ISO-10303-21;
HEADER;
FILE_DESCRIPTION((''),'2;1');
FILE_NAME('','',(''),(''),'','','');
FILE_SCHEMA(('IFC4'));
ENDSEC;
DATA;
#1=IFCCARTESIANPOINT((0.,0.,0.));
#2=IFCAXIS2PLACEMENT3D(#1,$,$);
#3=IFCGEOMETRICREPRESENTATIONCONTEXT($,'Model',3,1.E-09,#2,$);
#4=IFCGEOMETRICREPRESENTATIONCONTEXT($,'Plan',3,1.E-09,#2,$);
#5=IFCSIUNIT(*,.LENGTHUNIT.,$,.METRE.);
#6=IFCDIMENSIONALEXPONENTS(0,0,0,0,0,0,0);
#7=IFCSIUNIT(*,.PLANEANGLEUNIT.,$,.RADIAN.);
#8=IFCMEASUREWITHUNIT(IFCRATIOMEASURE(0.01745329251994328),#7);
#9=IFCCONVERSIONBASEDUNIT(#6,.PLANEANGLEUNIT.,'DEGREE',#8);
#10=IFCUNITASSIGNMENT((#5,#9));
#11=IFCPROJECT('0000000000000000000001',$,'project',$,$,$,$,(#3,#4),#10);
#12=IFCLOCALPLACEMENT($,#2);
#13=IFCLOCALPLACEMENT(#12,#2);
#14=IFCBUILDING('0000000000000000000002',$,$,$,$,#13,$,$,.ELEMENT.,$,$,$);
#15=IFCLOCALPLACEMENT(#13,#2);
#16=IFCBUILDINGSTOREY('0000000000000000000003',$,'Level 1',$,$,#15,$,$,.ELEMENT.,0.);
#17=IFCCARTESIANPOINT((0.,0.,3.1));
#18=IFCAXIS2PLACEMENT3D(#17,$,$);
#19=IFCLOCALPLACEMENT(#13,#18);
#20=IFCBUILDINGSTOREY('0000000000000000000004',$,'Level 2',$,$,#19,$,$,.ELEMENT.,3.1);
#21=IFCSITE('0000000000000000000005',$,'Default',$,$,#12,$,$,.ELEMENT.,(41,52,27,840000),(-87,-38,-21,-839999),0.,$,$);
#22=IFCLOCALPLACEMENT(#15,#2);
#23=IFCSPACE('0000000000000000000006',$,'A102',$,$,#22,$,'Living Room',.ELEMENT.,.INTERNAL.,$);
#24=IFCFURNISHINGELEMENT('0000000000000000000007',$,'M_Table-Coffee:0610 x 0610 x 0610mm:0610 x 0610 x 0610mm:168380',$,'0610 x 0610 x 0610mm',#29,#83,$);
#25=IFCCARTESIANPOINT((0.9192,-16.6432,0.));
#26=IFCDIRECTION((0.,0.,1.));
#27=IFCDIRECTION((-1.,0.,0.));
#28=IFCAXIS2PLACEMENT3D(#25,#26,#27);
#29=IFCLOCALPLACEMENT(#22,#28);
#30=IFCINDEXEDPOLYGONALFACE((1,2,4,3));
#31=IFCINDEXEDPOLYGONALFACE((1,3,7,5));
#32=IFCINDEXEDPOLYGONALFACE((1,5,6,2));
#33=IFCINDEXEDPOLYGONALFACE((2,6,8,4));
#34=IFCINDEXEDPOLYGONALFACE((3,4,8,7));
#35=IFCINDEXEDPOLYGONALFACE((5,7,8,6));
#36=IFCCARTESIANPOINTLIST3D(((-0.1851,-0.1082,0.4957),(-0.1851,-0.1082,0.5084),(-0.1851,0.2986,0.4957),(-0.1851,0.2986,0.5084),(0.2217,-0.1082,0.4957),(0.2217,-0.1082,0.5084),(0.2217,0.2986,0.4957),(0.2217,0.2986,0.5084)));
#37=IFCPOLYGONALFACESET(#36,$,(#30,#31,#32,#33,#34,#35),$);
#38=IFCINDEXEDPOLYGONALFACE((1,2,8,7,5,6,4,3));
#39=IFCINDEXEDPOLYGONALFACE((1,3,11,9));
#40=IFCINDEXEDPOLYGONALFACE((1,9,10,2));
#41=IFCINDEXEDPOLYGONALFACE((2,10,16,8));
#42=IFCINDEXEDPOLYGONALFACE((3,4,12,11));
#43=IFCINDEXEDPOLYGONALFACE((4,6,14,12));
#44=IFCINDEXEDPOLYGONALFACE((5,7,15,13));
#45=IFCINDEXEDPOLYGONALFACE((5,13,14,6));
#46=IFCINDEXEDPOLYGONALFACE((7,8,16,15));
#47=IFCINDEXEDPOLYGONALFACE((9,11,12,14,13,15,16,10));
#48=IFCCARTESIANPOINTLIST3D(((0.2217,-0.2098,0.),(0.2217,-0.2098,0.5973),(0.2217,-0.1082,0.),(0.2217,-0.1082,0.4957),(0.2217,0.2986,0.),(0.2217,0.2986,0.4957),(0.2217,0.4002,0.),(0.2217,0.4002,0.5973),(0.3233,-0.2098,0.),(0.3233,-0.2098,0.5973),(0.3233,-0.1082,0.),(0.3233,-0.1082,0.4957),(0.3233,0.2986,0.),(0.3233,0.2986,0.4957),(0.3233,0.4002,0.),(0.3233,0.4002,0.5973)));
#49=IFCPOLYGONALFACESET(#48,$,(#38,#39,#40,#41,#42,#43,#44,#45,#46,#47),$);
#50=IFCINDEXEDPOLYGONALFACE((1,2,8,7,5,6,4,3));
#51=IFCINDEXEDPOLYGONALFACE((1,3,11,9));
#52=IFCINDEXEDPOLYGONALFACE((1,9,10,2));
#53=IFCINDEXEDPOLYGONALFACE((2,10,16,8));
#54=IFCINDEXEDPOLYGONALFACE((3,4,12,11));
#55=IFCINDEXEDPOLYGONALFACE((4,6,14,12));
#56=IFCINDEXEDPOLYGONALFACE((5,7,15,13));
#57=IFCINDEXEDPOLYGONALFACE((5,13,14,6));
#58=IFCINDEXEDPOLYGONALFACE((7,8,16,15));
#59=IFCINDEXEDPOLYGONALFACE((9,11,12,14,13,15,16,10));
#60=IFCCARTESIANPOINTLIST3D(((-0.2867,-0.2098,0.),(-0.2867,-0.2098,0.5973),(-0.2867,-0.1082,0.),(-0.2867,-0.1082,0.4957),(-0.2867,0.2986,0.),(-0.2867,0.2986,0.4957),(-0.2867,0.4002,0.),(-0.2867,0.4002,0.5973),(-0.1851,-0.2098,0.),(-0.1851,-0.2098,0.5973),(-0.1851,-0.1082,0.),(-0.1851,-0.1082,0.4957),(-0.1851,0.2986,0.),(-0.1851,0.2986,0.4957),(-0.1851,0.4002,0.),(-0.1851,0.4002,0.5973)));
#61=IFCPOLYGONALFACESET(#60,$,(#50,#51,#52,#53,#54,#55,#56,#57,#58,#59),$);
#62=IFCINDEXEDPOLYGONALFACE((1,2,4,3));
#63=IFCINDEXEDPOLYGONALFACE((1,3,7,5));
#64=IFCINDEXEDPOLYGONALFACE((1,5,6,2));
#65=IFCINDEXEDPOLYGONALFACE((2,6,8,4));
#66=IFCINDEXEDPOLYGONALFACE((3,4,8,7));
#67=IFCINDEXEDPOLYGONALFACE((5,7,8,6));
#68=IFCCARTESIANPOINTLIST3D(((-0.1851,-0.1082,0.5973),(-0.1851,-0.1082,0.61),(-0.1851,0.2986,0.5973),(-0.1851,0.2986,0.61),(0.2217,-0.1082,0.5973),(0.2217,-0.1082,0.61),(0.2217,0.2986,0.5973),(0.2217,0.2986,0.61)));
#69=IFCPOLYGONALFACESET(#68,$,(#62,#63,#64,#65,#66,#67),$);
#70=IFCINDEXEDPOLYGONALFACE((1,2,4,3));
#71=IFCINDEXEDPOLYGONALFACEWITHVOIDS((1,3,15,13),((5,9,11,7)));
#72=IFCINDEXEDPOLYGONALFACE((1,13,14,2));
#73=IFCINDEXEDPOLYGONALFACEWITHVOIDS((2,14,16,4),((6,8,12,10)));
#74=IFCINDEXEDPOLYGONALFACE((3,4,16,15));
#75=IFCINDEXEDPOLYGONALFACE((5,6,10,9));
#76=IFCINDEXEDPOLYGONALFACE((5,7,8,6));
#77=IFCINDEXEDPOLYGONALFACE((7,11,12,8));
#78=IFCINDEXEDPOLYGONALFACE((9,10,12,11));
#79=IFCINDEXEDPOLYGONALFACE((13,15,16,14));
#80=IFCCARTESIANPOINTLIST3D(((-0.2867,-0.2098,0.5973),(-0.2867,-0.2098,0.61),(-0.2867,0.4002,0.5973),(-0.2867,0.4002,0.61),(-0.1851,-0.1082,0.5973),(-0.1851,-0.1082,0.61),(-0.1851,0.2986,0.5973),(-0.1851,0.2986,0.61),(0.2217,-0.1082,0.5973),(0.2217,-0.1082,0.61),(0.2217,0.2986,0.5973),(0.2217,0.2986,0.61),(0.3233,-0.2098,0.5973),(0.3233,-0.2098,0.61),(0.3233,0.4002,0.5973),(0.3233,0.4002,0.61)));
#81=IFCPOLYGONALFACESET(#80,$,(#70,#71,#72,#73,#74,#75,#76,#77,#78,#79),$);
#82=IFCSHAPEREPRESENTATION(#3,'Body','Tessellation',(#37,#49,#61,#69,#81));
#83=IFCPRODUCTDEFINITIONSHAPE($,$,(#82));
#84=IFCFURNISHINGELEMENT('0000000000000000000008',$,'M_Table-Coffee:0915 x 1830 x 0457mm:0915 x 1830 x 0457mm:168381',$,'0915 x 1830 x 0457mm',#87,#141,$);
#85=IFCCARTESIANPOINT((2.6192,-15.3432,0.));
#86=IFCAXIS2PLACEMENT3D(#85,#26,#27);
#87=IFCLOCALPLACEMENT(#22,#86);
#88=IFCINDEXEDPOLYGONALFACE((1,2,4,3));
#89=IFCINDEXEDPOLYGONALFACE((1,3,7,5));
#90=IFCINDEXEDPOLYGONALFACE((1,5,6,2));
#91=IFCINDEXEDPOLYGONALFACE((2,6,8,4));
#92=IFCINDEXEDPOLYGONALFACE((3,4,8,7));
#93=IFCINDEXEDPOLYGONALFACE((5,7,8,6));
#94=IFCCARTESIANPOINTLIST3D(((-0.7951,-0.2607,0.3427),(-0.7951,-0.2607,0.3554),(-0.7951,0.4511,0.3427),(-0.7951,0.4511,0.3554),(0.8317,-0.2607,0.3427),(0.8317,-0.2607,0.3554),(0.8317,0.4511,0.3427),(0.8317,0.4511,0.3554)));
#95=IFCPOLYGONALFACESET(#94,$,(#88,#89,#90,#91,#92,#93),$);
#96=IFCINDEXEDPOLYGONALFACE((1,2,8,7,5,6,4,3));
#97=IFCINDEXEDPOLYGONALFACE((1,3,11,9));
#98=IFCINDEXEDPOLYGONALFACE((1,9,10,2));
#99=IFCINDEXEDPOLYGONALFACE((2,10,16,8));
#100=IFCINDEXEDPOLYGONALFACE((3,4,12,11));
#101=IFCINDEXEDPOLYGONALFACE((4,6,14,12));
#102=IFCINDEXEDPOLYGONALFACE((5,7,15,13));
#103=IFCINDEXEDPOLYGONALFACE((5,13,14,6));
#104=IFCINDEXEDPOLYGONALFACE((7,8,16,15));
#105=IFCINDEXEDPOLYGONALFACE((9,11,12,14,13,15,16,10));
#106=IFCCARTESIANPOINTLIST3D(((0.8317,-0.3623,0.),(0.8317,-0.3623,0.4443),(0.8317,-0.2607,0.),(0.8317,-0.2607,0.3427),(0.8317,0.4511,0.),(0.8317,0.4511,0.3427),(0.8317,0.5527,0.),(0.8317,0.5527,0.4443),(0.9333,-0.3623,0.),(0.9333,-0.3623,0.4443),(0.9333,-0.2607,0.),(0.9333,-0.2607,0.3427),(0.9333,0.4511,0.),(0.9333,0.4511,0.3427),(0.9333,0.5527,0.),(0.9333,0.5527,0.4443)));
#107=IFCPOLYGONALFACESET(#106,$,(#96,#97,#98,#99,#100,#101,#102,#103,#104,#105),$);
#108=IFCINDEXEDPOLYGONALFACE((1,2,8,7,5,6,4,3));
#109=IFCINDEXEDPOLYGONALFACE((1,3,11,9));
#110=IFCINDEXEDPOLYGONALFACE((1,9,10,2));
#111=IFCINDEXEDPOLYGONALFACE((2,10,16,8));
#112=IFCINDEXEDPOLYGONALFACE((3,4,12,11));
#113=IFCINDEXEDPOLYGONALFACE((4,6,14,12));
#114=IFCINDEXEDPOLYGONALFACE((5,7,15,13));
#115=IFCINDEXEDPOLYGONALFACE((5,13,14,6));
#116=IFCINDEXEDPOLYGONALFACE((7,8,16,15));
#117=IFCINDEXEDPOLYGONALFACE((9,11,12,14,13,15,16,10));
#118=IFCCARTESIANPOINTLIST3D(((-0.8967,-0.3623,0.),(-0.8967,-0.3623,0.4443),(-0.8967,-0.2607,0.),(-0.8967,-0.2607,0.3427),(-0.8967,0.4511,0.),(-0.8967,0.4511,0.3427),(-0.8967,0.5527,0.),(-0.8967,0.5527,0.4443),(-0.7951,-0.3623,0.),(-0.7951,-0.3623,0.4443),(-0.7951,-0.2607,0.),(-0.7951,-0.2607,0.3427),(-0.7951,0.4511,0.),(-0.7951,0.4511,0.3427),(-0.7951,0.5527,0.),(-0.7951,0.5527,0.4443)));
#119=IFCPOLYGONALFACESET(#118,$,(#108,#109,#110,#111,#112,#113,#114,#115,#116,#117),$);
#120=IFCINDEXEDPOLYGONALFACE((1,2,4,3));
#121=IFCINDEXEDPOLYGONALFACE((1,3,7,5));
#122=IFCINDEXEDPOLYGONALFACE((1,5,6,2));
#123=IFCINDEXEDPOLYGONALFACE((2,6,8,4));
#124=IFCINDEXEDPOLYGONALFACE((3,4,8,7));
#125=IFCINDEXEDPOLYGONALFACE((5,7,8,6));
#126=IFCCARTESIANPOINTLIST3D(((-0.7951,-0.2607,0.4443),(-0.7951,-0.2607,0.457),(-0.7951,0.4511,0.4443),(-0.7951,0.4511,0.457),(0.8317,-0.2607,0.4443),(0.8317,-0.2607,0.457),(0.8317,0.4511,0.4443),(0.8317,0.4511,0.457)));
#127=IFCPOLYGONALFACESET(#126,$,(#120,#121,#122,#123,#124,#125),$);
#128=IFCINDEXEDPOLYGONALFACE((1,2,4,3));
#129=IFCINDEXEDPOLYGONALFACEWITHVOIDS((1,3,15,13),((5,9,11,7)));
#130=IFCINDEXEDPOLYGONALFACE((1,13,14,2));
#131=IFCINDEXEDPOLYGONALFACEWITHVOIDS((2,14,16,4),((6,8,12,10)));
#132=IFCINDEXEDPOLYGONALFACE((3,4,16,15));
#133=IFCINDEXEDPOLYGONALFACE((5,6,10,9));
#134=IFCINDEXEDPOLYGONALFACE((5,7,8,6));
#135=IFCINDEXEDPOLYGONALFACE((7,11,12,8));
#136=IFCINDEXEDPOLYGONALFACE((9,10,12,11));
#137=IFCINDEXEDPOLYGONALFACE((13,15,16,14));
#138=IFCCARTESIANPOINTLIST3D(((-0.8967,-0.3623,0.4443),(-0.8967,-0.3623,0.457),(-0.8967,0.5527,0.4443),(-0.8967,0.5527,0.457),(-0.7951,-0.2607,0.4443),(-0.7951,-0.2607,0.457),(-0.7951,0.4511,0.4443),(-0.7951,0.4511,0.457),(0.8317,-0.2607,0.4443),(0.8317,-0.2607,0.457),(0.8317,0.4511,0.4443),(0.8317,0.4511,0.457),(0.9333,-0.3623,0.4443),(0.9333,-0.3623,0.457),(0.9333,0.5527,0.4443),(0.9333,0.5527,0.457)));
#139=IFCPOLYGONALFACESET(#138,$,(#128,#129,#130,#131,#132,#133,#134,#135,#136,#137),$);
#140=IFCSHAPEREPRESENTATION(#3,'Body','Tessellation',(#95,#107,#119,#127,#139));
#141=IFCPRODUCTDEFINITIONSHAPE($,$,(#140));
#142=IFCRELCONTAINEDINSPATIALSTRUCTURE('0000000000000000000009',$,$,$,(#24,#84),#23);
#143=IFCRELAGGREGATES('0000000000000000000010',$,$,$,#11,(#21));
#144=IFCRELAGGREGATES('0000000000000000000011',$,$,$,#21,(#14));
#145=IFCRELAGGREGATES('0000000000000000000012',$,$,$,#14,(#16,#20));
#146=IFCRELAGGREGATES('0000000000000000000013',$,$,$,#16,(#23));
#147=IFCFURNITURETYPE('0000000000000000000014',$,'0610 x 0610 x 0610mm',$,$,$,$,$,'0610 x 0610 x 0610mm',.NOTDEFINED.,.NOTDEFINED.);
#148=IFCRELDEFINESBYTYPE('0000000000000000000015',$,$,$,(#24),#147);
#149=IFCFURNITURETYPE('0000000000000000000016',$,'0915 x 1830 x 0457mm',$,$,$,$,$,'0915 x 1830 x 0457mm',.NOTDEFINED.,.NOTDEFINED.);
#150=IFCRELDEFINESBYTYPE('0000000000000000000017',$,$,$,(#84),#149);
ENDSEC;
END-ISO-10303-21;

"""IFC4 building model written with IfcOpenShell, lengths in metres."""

from ifc_helpers import new_model, entity, si_unit, converted_unit, frame, origin, origin_2d_with_axis, place, context, project, spatial, polyline, rectangle, outline, extrude, source, transform, mapped, type_object, type_shapes, element, save


model = new_model("IFC4")

# Units and contexts
model_context = context("Model", 3, precision=1e-09, world=origin())
plan_context = context("Plan", 3, precision=1e-09, world=origin())
ifc_project = project(units=[si_unit("LENGTHUNIT", "METRE"), converted_unit("PLANEANGLEUNIT", "DEGREE", entity("IfcRatioMeasure", 0.01745329251994328), si_unit("PLANEANGLEUNIT", "RADIAN"), dimensions=[0, 0, 0, 0, 0, 0, 0])], contexts=[model_context, plan_context])

# Site, building, storey
site_placement = place(None, origin())
site = spatial("IfcSite", under=ifc_project, at=site_placement, Name="Default", CompositionType="ELEMENT", RefLatitude=(41, 52, 27, 840000), RefLongitude=(-87, -38, -21, -839999), RefElevation=0.0)
building_placement = place(site_placement, origin())
building = spatial("IfcBuilding", under=site, at=building_placement, CompositionType="ELEMENT")
storey_1_placement = place(building_placement, origin())
storey_1 = spatial("IfcBuildingStorey", under=building, at=storey_1_placement, Name="Level 1", CompositionType="ELEMENT", Elevation=0.0)

# Shared definitions
storey_2_placement = place(building_placement, frame((0.0, 0.0, 3.1)))
storey_2 = spatial("IfcBuildingStorey", under=building, at=storey_2_placement, Name="Level 2", CompositionType="ELEMENT", Elevation=3.1)

# Shared definitions
space_1_placement = place(storey_1_placement, origin())
space_1 = spatial("IfcSpace", under=storey_1, at=space_1_placement, Name="A102", LongName="Living Room", CompositionType="ELEMENT", PredefinedType="INTERNAL")

# Furnishing elements
furniture_type_1 = type_object("IfcFurnitureType", Name="0610 x 0610 x 0610mm", ElementType="0610 x 0610 x 0610mm", AssemblyPlace="NOTDEFINED")
shared_shape_1 = source(origin(), model_context, "Body", "SweptSolid", [
    extrude(rectangle(XDim=0.4068, YDim=0.4068, at=origin_2d_with_axis()), frame((0.0183, 0.0952, 0.4957), z_axis=(0.0, 0.0, 1.0), x_axis=(-1.0, 0.0, 0.0)), (0.0, 0.0, 1.0), 0.0127),
    extrude(outline(polyline([(-0.2732, -0.305), (0.324, -0.305), (0.324, 0.305), (-0.2732, 0.305), (-0.2732, 0.2034), (0.2225, 0.2034), (0.2225, -0.2034), (-0.2732, -0.2034), (-0.2732, -0.305)])), frame((0.2217, 0.0952, 0.2732), z_axis=(1.0, 0.0, 0.0), x_axis=(0.0, 0.0, 1.0)), (0.0, 0.0, 1.0), 0.1016),
    extrude(outline(polyline([(-0.305, -0.3241), (0.305, -0.3241), (0.305, 0.2733), (0.2034, 0.2733), (0.2034, -0.2224), (-0.2034, -0.2224), (-0.2034, 0.2733), (-0.305, 0.2733), (-0.305, -0.3241)])), frame((-0.2867, 0.0952, 0.2733), z_axis=(1.0, 0.0, 0.0), x_axis=(0.0, -1.0, 0.0)), (0.0, 0.0, 1.0), 0.1016),
    extrude(rectangle(XDim=0.4068, YDim=0.4068, at=origin_2d_with_axis()), frame((0.0183, 0.0952, 0.5973), z_axis=(0.0, 0.0, 1.0), x_axis=(-1.0, 0.0, 0.0)), (0.0, 0.0, 1.0), 0.0127),
    extrude(outline(polyline([(-0.305, -0.305), (0.305, -0.305), (0.305, 0.305), (-0.305, 0.305), (-0.305, -0.305)]), holes=[polyline([(-0.2034, -0.2034), (-0.2034, 0.2034), (0.2034, 0.2034), (0.2034, -0.2034), (-0.2034, -0.2034)])]), frame((0.0183, 0.0952, 0.5973), z_axis=(0.0, 0.0, 1.0), x_axis=(-1.0, 0.0, 0.0)), (0.0, 0.0, 1.0), 0.0127),
])
type_shapes(furniture_type_1, [shared_shape_1])
for number, where, z_axis, x_axis, name in (
    (1, (0.9192, -16.6432, 0.0), (0.0, 0.0, 1.0), (-1.0, 0.0, 0.0), "M_Table-Coffee:0610 x 0610 x 0610mm:0610 x 0610 x 0610mm:168380"),
):
    element("IfcFurnishingElement", number, at=place(space_1_placement, frame(where, z_axis=z_axis, x_axis=x_axis)), inside=space_1, type_object=furniture_type_1, Name=name, ObjectType="0610 x 0610 x 0610mm", context=model_context, shape_type="MappedRepresentation", body=[
        mapped(shared_shape_1, transform((0.0, 0.0, 0.0), scale=1.0)),
    ])
furniture_type_2 = type_object("IfcFurnitureType", Name="0915 x 1830 x 0457mm", ElementType="0915 x 1830 x 0457mm", AssemblyPlace="NOTDEFINED")
shared_shape_2 = source(origin(), model_context, "Body", "SweptSolid", [
    extrude(rectangle(XDim=1.6268, YDim=0.7118, at=origin_2d_with_axis()), frame((0.0183, 0.0952, 0.3427), z_axis=(0.0, 0.0, 1.0), x_axis=(-1.0, 0.0, 0.0)), (0.0, 0.0, 1.0), 0.0127),
    extrude(outline(polyline([(-0.1967, -0.4575), (0.2475, -0.4575), (0.2475, 0.4575), (-0.1967, 0.4575), (-0.1967, 0.3559), (0.146, 0.3559), (0.146, -0.3559), (-0.1967, -0.3559), (-0.1967, -0.4575)])), frame((0.8317, 0.0952, 0.1967), z_axis=(1.0, 0.0, 0.0), x_axis=(0.0, 0.0, 1.0)), (0.0, 0.0, 1.0), 0.1016),
    extrude(outline(polyline([(-0.4575, -0.2476), (0.4575, -0.2476), (0.4575, 0.1968), (0.3559, 0.1968), (0.3559, -0.1459), (-0.3559, -0.1459), (-0.3559, 0.1968), (-0.4575, 0.1968), (-0.4575, -0.2476)])), frame((-0.8967, 0.0952, 0.1968), z_axis=(1.0, 0.0, 0.0), x_axis=(0.0, -1.0, 0.0)), (0.0, 0.0, 1.0), 0.1016),
    extrude(rectangle(XDim=1.6268, YDim=0.7118, at=origin_2d_with_axis()), frame((0.0183, 0.0952, 0.4443), z_axis=(0.0, 0.0, 1.0), x_axis=(-1.0, 0.0, 0.0)), (0.0, 0.0, 1.0), 0.0127),
    extrude(outline(polyline([(-0.915, -0.4575), (0.915, -0.4575), (0.915, 0.4575), (-0.915, 0.4575), (-0.915, -0.4575)]), holes=[polyline([(-0.8134, -0.3559), (-0.8134, 0.3559), (0.8134, 0.3559), (0.8134, -0.3559), (-0.8134, -0.3559)])]), frame((0.0183, 0.0952, 0.4443), z_axis=(0.0, 0.0, 1.0), x_axis=(-1.0, 0.0, 0.0)), (0.0, 0.0, 1.0), 0.0127),
])
type_shapes(furniture_type_2, [shared_shape_2])
furnishing_1_placement = place(space_1_placement, frame((2.6192, -15.3432, 0.0), z_axis=(0.0, 0.0, 1.0), x_axis=(-1.0, 0.0, 0.0)))
element("IfcFurnishingElement", 2, at=furnishing_1_placement, inside=space_1, type_object=furniture_type_2, Name="M_Table-Coffee:0915 x 1830 x 0457mm:0915 x 1830 x 0457mm:168381", ObjectType="0915 x 1830 x 0457mm", context=model_context, shape_type="MappedRepresentation", body=[
    mapped(shared_shape_2, transform((0.0, 0.0, 0.0), scale=1.0)),
])

save(model, "model.ifc")
